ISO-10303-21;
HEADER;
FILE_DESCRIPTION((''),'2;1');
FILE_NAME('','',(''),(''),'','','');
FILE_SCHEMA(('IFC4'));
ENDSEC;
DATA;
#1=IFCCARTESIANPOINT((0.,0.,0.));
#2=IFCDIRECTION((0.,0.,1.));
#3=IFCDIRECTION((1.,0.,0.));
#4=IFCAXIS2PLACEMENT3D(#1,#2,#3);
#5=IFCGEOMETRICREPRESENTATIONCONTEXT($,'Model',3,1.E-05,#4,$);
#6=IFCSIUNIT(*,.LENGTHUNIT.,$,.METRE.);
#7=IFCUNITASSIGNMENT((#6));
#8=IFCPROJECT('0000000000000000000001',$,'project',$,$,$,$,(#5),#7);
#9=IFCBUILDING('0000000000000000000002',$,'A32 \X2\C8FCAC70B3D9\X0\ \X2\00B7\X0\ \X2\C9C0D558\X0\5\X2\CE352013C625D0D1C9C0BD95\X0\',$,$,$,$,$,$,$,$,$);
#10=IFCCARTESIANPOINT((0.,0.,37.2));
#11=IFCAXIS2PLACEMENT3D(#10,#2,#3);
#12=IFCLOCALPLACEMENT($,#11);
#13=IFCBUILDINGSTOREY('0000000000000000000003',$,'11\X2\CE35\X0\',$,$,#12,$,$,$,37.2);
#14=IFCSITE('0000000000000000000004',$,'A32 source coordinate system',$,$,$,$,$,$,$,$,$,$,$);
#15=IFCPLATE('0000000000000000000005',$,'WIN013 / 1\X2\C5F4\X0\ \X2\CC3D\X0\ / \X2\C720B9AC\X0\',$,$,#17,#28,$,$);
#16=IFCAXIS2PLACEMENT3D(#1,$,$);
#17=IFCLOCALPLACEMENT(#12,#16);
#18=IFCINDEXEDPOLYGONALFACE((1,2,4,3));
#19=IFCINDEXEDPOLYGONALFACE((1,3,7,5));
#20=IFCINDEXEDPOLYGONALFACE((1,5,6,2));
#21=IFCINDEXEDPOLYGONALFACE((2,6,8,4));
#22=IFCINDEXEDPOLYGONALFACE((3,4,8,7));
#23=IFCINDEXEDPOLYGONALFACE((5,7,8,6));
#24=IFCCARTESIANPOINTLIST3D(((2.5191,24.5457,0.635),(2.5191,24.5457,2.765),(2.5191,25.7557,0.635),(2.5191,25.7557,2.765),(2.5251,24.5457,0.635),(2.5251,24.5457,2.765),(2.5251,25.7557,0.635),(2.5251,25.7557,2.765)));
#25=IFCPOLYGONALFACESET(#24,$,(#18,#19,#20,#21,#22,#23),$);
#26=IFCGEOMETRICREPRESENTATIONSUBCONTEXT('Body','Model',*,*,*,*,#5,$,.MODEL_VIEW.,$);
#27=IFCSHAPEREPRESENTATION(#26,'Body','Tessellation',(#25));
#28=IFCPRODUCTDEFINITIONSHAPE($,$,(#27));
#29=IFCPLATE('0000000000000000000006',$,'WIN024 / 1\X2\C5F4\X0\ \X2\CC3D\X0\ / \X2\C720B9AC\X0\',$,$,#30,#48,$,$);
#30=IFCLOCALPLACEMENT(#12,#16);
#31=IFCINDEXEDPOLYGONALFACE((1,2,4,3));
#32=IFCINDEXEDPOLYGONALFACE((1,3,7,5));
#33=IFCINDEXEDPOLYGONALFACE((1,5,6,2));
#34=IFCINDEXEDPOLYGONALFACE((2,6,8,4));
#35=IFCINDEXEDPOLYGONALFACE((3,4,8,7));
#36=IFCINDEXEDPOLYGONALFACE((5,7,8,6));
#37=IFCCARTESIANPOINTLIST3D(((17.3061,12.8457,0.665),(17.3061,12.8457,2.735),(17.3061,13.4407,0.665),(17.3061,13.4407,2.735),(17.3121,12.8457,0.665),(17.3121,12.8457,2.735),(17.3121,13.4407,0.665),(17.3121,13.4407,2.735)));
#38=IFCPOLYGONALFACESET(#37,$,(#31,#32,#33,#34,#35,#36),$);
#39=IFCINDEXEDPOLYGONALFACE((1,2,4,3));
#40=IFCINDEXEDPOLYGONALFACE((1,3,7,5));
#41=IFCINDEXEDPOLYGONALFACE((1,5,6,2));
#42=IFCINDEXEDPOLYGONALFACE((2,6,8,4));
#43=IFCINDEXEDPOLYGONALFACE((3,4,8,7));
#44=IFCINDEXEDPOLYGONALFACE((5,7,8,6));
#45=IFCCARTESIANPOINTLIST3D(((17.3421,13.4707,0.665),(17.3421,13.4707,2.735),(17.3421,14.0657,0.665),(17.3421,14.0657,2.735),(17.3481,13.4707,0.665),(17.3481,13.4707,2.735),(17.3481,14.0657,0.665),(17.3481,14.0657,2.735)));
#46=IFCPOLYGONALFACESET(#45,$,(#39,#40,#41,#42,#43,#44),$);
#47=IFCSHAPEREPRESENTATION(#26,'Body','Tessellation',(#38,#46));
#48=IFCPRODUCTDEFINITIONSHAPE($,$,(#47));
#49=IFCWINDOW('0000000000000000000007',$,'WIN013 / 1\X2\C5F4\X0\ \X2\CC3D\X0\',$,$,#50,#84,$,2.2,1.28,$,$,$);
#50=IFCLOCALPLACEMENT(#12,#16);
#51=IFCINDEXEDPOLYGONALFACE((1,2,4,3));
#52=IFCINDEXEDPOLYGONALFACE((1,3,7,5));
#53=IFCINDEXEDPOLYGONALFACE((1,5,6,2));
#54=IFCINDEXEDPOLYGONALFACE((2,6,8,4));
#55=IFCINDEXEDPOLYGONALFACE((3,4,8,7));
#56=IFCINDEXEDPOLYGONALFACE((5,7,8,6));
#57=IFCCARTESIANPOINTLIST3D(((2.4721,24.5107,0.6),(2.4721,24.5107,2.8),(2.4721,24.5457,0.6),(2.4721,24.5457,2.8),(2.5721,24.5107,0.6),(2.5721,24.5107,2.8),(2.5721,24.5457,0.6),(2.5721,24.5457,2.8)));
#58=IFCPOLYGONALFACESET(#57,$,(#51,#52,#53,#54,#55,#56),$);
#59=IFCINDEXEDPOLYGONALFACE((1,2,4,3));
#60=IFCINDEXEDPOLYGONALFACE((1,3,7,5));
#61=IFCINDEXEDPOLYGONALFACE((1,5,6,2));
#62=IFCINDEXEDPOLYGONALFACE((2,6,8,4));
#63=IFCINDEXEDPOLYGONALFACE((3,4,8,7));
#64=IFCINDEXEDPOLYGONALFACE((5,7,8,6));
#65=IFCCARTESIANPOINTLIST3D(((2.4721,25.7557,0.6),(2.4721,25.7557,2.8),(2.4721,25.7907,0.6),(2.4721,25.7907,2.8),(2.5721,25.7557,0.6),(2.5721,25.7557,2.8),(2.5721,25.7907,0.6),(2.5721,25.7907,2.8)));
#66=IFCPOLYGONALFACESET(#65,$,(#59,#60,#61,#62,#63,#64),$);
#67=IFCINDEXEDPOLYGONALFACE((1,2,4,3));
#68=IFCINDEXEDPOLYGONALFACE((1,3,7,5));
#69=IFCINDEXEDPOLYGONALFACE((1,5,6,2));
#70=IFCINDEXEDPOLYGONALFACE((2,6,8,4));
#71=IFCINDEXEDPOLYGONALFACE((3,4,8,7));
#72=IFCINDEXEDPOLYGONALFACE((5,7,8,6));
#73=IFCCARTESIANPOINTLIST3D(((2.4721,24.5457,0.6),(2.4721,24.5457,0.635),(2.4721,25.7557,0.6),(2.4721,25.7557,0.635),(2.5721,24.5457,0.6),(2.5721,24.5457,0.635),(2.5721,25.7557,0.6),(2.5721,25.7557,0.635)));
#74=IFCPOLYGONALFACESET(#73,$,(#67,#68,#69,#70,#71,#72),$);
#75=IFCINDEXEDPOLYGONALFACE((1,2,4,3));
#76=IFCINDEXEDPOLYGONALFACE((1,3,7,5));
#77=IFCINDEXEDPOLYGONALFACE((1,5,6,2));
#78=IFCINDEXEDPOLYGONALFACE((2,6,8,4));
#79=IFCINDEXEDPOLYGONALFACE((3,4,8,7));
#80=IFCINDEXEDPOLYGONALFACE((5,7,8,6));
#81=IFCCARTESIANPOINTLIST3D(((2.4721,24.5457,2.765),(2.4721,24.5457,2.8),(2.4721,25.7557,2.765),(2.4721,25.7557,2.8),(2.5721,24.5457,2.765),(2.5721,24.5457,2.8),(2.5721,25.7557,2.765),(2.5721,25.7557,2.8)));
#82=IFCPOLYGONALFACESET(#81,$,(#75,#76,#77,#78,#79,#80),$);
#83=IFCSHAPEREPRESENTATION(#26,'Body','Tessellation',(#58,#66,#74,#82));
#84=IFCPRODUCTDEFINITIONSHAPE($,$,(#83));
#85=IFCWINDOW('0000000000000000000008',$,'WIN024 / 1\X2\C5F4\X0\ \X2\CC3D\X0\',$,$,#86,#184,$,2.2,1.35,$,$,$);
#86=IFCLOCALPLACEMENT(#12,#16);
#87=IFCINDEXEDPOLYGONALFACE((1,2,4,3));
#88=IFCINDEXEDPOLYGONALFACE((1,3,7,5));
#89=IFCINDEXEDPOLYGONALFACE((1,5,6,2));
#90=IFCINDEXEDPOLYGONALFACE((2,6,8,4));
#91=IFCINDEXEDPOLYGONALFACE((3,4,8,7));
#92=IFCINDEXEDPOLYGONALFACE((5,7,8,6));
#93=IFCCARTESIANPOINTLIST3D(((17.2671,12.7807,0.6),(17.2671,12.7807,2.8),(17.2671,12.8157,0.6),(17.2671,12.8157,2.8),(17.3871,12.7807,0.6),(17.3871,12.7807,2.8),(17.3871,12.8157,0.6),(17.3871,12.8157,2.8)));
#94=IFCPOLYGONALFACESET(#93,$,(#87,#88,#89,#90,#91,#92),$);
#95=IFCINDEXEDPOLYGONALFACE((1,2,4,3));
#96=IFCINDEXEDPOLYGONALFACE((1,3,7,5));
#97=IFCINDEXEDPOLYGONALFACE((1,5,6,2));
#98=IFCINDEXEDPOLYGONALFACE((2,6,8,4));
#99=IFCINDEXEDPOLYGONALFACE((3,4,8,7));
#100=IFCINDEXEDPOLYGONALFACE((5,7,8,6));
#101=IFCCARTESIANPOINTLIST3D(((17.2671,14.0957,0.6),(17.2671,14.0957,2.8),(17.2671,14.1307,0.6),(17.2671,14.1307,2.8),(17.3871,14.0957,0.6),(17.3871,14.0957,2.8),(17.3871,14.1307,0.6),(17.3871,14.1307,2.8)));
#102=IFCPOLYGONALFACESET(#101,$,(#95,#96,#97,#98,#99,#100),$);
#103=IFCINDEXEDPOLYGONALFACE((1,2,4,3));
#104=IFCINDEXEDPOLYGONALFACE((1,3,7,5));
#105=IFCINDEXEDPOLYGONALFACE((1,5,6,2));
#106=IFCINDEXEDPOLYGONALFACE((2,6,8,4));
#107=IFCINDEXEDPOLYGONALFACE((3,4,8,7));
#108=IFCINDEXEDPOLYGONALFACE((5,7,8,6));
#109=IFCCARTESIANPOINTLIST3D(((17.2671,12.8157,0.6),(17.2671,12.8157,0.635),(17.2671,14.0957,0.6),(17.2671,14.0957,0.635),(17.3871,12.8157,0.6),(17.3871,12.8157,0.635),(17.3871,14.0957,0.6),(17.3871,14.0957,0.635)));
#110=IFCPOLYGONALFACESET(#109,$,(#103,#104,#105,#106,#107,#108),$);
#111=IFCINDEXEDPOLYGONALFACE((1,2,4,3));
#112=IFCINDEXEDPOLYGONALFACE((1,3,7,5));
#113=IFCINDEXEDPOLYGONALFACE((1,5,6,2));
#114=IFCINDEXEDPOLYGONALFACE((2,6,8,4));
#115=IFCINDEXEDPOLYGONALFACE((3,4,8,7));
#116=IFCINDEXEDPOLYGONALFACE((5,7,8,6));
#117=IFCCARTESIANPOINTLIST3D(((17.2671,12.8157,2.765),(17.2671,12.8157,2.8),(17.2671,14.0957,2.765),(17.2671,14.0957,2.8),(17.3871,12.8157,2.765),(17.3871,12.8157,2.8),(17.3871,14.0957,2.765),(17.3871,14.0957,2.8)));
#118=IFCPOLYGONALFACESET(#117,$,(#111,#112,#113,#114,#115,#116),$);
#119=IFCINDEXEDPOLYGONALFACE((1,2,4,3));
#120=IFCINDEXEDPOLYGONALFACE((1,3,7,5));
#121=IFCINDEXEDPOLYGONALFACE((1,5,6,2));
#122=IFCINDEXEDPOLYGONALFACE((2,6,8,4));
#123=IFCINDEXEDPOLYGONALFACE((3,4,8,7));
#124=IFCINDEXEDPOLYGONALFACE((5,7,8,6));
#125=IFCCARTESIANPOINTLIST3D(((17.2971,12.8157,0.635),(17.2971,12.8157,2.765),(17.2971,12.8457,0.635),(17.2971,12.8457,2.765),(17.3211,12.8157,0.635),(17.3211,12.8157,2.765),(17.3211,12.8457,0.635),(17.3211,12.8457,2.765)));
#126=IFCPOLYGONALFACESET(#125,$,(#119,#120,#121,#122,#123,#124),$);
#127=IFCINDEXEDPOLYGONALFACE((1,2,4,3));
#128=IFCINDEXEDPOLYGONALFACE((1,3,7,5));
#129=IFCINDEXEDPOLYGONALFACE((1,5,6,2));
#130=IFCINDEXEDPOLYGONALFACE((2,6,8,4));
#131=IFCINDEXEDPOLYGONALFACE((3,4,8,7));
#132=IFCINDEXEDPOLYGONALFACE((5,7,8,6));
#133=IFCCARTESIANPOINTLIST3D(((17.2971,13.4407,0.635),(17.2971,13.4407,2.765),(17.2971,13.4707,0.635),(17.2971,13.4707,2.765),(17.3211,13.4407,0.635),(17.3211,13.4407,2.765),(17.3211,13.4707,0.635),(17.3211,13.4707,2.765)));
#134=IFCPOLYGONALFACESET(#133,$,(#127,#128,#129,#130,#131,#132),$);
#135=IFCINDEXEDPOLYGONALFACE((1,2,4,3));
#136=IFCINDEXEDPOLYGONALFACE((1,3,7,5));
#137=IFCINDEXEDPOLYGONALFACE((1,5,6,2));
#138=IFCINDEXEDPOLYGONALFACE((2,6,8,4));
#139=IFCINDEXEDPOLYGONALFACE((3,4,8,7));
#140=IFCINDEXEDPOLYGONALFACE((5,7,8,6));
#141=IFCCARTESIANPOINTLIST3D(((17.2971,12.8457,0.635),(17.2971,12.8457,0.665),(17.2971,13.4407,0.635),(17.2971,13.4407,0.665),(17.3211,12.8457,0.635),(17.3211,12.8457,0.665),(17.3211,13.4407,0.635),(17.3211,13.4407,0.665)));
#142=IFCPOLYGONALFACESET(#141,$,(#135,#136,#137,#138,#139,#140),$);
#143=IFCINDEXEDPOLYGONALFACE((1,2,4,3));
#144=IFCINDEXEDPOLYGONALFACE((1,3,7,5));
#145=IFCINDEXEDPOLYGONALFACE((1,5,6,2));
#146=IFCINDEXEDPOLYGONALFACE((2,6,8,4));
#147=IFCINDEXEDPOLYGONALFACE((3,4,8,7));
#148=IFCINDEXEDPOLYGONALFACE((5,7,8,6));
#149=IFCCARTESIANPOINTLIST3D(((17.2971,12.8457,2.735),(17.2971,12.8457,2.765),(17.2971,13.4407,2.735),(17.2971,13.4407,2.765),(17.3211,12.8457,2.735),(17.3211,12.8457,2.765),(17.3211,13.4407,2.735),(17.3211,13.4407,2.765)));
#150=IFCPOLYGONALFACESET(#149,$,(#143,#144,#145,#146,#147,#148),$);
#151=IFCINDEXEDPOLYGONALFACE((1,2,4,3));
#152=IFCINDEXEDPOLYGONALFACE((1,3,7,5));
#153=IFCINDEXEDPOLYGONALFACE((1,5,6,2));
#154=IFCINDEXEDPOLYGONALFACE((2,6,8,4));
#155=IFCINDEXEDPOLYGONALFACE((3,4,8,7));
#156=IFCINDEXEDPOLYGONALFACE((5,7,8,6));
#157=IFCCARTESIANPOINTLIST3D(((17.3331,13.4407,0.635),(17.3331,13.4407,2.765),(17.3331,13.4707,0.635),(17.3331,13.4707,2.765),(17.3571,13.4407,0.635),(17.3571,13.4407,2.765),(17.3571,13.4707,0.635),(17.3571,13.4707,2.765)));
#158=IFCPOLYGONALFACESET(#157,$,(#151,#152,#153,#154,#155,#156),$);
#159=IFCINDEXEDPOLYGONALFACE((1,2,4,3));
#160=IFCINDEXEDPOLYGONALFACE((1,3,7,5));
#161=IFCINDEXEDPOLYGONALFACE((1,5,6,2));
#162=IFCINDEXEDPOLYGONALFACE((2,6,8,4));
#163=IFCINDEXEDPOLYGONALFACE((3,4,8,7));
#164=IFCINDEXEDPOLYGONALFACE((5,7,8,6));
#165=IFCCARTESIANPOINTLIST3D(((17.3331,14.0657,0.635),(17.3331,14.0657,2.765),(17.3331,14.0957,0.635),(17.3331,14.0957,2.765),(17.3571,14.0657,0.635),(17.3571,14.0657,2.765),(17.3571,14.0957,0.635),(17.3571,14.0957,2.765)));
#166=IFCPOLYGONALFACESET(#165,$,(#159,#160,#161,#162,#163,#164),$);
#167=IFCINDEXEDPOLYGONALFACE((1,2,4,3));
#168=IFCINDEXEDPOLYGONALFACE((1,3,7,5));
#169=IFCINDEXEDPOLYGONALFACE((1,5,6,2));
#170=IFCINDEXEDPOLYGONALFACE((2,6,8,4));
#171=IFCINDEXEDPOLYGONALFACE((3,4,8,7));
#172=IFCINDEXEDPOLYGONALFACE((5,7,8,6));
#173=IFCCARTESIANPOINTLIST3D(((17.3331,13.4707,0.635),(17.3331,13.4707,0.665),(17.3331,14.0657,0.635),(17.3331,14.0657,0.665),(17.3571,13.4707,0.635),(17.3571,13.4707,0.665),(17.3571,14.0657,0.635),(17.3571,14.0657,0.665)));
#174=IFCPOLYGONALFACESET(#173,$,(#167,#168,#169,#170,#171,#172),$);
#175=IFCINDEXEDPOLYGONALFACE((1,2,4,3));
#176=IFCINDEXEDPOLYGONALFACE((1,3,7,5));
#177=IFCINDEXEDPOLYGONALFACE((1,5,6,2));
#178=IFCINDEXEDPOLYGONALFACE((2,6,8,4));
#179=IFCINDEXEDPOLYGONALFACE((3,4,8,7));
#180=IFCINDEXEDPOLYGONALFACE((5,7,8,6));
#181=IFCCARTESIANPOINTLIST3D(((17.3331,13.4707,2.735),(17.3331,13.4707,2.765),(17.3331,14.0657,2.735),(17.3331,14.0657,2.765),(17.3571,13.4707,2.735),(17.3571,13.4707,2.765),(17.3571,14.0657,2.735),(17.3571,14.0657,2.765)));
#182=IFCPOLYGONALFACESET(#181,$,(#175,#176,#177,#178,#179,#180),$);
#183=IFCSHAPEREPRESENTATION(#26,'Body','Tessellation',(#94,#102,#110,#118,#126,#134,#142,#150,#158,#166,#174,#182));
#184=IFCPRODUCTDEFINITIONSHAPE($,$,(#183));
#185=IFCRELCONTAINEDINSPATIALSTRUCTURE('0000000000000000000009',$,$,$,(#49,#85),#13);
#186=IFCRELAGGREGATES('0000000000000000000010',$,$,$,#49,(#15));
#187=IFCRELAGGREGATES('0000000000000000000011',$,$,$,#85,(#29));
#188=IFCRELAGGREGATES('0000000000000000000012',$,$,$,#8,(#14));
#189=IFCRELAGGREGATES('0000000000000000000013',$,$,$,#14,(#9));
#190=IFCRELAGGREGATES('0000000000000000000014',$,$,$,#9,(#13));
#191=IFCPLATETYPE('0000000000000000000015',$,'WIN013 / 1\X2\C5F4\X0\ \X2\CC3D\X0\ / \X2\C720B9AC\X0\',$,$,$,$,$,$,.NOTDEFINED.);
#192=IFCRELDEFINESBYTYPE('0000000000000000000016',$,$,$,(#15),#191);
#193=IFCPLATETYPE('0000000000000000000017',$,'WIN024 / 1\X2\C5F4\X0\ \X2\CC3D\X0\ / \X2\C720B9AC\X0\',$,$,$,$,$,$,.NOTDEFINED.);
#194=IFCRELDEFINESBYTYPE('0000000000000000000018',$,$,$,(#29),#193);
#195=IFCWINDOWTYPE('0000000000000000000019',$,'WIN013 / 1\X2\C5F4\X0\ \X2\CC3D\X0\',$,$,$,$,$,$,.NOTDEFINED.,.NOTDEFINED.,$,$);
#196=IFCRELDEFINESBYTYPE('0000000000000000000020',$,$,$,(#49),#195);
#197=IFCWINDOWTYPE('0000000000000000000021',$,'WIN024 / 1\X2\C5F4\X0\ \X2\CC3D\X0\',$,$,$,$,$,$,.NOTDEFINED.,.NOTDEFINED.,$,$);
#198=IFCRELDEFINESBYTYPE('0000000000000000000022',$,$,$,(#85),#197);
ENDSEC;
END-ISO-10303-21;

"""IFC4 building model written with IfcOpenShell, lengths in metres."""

from ifc_helpers import new_model, si_unit, frame, origin, origin_with_axes, place, context, subcontext, project, spatial, polyline, outline, extrude, source, transform, mapped, type_object, type_shapes, element, aggregate, save


model = new_model("IFC4")

# Units and contexts
model_context = context("Model", 3, precision=1e-05, world=origin_with_axes())
body_context = subcontext(model_context, "Body", "Model", "MODEL_VIEW")
ifc_project = project(units=[si_unit("LENGTHUNIT", "METRE")], contexts=[model_context])

# Plates
plate_type_1 = type_object("IfcPlateType", Name="WIN013 / 1열 창 / 유리", PredefinedType="NOTDEFINED")
shared_shape_1 = source(origin(), body_context, "Body", "SweptSolid", [
    extrude(outline(polyline([(2.5191, 24.5457), (2.5191, 25.7557), (2.5251, 25.7557), (2.5251, 24.5457), (2.5191, 24.5457)])), frame((0.0, 0.0, 0.635)), (0.0, 0.0, 1.0), 2.13),
])
type_shapes(plate_type_1, [shared_shape_1])
storey_placement = place(None, frame((0.0, 0.0, 37.2), z_axis=(0.0, 0.0, 1.0), x_axis=(1.0, 0.0, 0.0)))
window_1_placement = place(storey_placement, origin_with_axes())
plate_1_placement = place(window_1_placement, origin_with_axes())
plate_1 = element("IfcPlate", 1, at=plate_1_placement, type_object=plate_type_1, Name="WIN013 / 1열 창 / 유리", context=body_context, shape_type="MappedRepresentation", body=[
    mapped(shared_shape_1, transform((0.0, 0.0, 0.0), scale=1.0)),
])
plate_type_2 = type_object("IfcPlateType", Name="WIN024 / 1열 창 / 유리", PredefinedType="NOTDEFINED")
shared_shape_2 = source(origin(), body_context, "Body", "SweptSolid", [
    extrude(outline(polyline([(17.3061, 12.8457), (17.3061, 13.4407), (17.3121, 13.4407), (17.3121, 12.8457), (17.3061, 12.8457)])), frame((0.0, 0.0, 0.665)), (0.0, 0.0, 1.0), 2.07),
    extrude(outline(polyline([(17.3421, 13.4707), (17.3421, 14.0657), (17.3481, 14.0657), (17.3481, 13.4707), (17.3421, 13.4707)])), frame((0.0, 0.0, 0.665)), (0.0, 0.0, 1.0), 2.07),
])
type_shapes(plate_type_2, [shared_shape_2])
window_2_placement = place(storey_placement, origin_with_axes())
plate_2_placement = place(window_2_placement, origin_with_axes())
plate_2 = element("IfcPlate", 2, at=plate_2_placement, type_object=plate_type_2, Name="WIN024 / 1열 창 / 유리", context=body_context, shape_type="MappedRepresentation", body=[
    mapped(shared_shape_2, transform((0.0, 0.0, 0.0), scale=1.0)),
])

# Site, building, storey
site = spatial("IfcSite", under=ifc_project, Name="A32 source coordinate system")
building = spatial("IfcBuilding", under=site, Name="A32 주거동 · 지하5층–옥탑지붕")
storey = spatial("IfcBuildingStorey", under=building, at=storey_placement, Name="11층", Elevation=37.2)

# Windows
window_type_1 = type_object("IfcWindowType", Name="WIN013 / 1열 창", PartitioningType="NOTDEFINED", PredefinedType="NOTDEFINED")
shared_shape_3 = source(origin(), body_context, "Body", "SweptSolid", [
    extrude(outline(polyline([(2.4721, 24.5107), (2.4721, 24.5457), (2.5721, 24.5457), (2.5721, 24.5107), (2.4721, 24.5107)])), frame((0.0, 0.0, 0.6)), (0.0, 0.0, 1.0), 2.2),
    extrude(outline(polyline([(2.4721, 25.7557), (2.4721, 25.7907), (2.5721, 25.7907), (2.5721, 25.7557), (2.4721, 25.7557)])), frame((0.0, 0.0, 0.6)), (0.0, 0.0, 1.0), 2.2),
    extrude(outline(polyline([(2.4721, 24.5457), (2.4721, 25.7557), (2.5721, 25.7557), (2.5721, 24.5457), (2.4721, 24.5457)])), frame((0.0, 0.0, 0.6)), (0.0, 0.0, 1.0), 0.035),
    extrude(outline(polyline([(2.4721, 24.5457), (2.4721, 25.7557), (2.5721, 25.7557), (2.5721, 24.5457), (2.4721, 24.5457)])), frame((0.0, 0.0, 2.765)), (0.0, 0.0, 1.0), 0.035),
])
type_shapes(window_type_1, [shared_shape_3])
window_1 = element("IfcWindow", 3, at=window_1_placement, inside=storey, type_object=window_type_1, Name="WIN013 / 1열 창", OverallHeight=2.2, OverallWidth=1.28, context=body_context, shape_type="MappedRepresentation", body=[
    mapped(shared_shape_3, transform((0.0, 0.0, 0.0), scale=1.0)),
])
aggregate(window_1, [plate_1])
window_type_2 = type_object("IfcWindowType", Name="WIN024 / 1열 창", PartitioningType="NOTDEFINED", PredefinedType="NOTDEFINED")
shared_shape_4 = source(origin(), body_context, "Body", "SweptSolid", [
    extrude(outline(polyline([(17.2671, 12.7807), (17.2671, 12.8157), (17.3871, 12.8157), (17.3871, 12.7807), (17.2671, 12.7807)])), frame((0.0, 0.0, 0.6)), (0.0, 0.0, 1.0), 2.2),
    extrude(outline(polyline([(17.2671, 14.0957), (17.2671, 14.1307), (17.3871, 14.1307), (17.3871, 14.0957), (17.2671, 14.0957)])), frame((0.0, 0.0, 0.6)), (0.0, 0.0, 1.0), 2.2),
    extrude(outline(polyline([(17.2671, 12.8157), (17.2671, 14.0957), (17.3871, 14.0957), (17.3871, 12.8157), (17.2671, 12.8157)])), frame((0.0, 0.0, 0.6)), (0.0, 0.0, 1.0), 0.035),
    extrude(outline(polyline([(17.2671, 12.8157), (17.2671, 14.0957), (17.3871, 14.0957), (17.3871, 12.8157), (17.2671, 12.8157)])), frame((0.0, 0.0, 2.765)), (0.0, 0.0, 1.0), 0.035),
    extrude(outline(polyline([(17.2971, 12.8157), (17.2971, 12.8457), (17.3211, 12.8457), (17.3211, 12.8157), (17.2971, 12.8157)])), frame((0.0, 0.0, 0.635)), (0.0, 0.0, 1.0), 2.13),
    extrude(outline(polyline([(17.2971, 13.4407), (17.2971, 13.4707), (17.3211, 13.4707), (17.3211, 13.4407), (17.2971, 13.4407)])), frame((0.0, 0.0, 0.635)), (0.0, 0.0, 1.0), 2.13),
    extrude(outline(polyline([(17.2971, 12.8457), (17.2971, 13.4407), (17.3211, 13.4407), (17.3211, 12.8457), (17.2971, 12.8457)])), frame((0.0, 0.0, 0.635)), (0.0, 0.0, 1.0), 0.03),
    extrude(outline(polyline([(17.2971, 12.8457), (17.2971, 13.4407), (17.3211, 13.4407), (17.3211, 12.8457), (17.2971, 12.8457)])), frame((0.0, 0.0, 2.735)), (0.0, 0.0, 1.0), 0.03),
    extrude(outline(polyline([(17.3331, 13.4407), (17.3331, 13.4707), (17.3571, 13.4707), (17.3571, 13.4407), (17.3331, 13.4407)])), frame((0.0, 0.0, 0.635)), (0.0, 0.0, 1.0), 2.13),
    extrude(outline(polyline([(17.3331, 14.0657), (17.3331, 14.0957), (17.3571, 14.0957), (17.3571, 14.0657), (17.3331, 14.0657)])), frame((0.0, 0.0, 0.635)), (0.0, 0.0, 1.0), 2.13),
    extrude(outline(polyline([(17.3331, 13.4707), (17.3331, 14.0657), (17.3571, 14.0657), (17.3571, 13.4707), (17.3331, 13.4707)])), frame((0.0, 0.0, 0.635)), (0.0, 0.0, 1.0), 0.03),
    extrude(outline(polyline([(17.3331, 13.4707), (17.3331, 14.0657), (17.3571, 14.0657), (17.3571, 13.4707), (17.3331, 13.4707)])), frame((0.0, 0.0, 2.735)), (0.0, 0.0, 1.0), 0.03),
])
type_shapes(window_type_2, [shared_shape_4])
window_2 = element("IfcWindow", 4, at=window_2_placement, inside=storey, type_object=window_type_2, Name="WIN024 / 1열 창", OverallHeight=2.2, OverallWidth=1.35, context=body_context, shape_type="MappedRepresentation", body=[
    mapped(shared_shape_4, transform((0.0, 0.0, 0.0), scale=1.0)),
])
aggregate(window_2, [plate_2])

save(model, "model.ifc")
